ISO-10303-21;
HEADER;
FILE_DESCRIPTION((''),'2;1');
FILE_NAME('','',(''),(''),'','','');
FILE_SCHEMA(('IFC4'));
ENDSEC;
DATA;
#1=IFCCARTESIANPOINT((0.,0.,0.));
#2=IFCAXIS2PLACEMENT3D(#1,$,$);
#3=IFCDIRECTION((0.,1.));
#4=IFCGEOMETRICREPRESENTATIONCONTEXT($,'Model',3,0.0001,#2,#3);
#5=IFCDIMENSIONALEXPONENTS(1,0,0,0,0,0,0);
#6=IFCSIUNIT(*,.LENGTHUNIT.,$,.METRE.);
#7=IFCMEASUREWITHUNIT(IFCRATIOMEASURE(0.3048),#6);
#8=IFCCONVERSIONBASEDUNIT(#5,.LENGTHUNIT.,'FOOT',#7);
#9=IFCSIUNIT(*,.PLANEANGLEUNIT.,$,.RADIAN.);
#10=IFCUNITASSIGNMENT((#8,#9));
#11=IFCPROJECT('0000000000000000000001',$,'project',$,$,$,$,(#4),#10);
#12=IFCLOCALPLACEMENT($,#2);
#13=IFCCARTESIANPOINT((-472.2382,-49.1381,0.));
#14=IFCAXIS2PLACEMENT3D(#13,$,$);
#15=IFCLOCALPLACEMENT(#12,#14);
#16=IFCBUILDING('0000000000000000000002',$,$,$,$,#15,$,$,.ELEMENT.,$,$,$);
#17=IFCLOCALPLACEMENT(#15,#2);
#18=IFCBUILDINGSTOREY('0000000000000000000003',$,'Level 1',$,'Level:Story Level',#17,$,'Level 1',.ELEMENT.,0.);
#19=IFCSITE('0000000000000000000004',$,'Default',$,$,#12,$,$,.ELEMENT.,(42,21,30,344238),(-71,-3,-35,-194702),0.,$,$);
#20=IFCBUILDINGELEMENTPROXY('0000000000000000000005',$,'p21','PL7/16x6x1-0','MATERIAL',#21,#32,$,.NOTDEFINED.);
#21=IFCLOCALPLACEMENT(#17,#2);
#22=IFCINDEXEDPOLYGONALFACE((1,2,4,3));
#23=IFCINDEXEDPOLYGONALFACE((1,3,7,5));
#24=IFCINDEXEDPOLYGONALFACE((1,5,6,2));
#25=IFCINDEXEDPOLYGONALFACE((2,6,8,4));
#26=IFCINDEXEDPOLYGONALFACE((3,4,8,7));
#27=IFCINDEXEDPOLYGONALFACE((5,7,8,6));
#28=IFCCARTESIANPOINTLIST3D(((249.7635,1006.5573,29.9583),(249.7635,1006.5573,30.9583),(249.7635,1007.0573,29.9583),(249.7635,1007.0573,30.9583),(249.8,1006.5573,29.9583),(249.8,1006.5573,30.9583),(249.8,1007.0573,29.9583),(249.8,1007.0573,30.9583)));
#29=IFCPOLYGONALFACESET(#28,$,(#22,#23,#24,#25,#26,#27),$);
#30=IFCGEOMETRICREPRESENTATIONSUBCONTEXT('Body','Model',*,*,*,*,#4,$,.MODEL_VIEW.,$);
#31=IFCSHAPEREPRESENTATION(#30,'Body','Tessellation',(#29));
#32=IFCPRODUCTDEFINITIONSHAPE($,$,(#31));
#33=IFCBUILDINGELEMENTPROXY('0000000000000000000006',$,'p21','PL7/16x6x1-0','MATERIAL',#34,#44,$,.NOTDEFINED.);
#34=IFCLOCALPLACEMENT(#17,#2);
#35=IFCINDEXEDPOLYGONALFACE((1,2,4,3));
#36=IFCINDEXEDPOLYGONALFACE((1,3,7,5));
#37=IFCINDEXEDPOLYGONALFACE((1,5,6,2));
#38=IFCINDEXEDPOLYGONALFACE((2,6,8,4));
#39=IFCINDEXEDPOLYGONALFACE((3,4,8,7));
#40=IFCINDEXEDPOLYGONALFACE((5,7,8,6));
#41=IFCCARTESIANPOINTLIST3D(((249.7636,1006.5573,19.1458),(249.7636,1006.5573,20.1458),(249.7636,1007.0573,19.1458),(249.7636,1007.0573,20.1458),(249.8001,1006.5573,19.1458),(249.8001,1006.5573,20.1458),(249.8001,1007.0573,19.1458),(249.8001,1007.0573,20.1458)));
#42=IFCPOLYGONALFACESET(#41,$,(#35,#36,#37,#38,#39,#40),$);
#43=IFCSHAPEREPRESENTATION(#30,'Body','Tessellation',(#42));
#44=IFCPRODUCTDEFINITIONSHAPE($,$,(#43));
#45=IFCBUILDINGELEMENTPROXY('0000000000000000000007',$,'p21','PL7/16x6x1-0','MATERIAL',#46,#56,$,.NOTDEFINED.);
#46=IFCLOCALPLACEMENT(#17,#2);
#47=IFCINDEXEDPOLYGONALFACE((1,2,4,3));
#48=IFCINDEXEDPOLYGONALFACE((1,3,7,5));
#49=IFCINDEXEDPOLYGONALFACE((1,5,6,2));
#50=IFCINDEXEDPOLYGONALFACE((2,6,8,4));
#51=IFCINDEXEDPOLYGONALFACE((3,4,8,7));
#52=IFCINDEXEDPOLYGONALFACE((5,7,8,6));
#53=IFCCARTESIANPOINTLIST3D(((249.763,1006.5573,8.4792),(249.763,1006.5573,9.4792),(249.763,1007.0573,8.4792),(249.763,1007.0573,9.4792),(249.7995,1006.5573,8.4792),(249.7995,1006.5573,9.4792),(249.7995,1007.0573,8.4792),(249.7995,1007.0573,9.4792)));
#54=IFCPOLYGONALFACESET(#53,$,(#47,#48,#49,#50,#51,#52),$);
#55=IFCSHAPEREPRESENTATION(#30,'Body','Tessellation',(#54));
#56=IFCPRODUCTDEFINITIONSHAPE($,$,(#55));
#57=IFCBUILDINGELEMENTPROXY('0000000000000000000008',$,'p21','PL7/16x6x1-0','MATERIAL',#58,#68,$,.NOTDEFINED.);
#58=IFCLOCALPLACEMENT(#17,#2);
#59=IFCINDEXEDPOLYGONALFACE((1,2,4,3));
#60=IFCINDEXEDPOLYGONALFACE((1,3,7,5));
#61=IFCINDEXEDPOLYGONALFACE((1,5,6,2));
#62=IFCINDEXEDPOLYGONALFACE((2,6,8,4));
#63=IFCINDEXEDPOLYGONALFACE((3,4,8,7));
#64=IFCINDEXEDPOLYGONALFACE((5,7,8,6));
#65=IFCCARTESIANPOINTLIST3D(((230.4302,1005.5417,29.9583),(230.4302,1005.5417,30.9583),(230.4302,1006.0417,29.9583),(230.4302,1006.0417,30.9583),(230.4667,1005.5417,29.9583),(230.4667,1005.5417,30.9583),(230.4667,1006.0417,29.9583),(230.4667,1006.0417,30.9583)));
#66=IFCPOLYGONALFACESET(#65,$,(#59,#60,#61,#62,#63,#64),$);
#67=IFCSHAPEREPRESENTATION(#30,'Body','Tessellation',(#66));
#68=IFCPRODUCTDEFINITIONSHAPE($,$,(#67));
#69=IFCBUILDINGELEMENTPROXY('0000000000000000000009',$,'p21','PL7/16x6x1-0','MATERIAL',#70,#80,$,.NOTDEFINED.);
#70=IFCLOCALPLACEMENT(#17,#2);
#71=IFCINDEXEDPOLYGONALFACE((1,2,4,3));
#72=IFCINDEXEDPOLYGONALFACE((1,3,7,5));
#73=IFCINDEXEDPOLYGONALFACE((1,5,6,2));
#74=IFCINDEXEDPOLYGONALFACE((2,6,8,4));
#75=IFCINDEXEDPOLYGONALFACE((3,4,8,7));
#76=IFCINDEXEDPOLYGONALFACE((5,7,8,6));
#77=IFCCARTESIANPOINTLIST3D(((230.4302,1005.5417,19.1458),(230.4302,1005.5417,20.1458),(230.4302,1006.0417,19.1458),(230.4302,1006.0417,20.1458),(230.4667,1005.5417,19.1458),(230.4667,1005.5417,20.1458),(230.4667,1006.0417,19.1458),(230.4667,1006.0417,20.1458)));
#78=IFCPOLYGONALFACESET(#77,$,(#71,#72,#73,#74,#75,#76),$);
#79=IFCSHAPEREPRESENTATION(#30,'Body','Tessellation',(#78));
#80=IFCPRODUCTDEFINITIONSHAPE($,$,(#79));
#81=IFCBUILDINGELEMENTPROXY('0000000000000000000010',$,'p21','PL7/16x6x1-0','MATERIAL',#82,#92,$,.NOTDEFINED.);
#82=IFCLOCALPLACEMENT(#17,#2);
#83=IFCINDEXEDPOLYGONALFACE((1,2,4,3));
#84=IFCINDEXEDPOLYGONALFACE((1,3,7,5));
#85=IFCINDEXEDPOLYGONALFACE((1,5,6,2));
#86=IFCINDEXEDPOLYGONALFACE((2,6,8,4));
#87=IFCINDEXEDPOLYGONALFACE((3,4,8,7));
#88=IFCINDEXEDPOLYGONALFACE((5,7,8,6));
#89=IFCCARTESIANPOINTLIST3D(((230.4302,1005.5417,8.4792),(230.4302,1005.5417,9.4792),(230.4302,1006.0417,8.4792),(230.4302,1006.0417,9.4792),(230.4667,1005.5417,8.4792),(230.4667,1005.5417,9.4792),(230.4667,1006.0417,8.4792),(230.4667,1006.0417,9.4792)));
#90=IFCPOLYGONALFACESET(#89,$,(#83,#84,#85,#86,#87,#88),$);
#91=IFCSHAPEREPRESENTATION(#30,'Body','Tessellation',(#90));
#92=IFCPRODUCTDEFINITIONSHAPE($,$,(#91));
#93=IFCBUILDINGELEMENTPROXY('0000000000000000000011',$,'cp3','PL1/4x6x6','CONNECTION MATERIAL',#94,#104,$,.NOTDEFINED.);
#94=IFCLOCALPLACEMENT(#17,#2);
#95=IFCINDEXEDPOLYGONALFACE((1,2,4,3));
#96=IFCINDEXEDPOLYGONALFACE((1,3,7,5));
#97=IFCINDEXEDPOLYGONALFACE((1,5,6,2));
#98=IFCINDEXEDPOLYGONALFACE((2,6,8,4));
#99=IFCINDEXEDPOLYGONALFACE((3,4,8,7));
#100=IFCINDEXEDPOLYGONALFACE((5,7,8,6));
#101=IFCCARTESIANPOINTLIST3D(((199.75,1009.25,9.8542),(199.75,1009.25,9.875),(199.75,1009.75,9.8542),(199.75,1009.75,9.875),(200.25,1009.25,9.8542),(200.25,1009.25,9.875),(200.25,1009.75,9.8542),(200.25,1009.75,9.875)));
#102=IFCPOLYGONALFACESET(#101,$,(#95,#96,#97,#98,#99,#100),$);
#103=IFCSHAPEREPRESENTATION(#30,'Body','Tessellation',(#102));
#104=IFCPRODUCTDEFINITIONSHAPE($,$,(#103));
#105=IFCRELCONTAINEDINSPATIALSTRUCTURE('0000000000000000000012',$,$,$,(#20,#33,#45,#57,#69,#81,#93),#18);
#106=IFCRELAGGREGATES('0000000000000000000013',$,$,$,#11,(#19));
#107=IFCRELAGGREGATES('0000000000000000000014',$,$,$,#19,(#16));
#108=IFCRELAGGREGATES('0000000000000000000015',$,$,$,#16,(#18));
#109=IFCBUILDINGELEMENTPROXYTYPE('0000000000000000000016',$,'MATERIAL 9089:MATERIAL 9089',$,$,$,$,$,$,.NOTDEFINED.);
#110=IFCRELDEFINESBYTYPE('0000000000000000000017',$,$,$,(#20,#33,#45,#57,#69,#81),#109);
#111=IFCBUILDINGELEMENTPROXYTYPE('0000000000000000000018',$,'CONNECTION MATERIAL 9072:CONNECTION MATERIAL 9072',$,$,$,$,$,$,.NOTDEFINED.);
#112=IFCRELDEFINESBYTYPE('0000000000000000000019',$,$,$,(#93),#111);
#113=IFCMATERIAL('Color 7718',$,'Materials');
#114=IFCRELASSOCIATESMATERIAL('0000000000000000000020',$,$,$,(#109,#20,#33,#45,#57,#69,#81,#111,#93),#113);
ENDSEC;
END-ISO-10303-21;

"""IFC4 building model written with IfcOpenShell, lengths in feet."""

from ifc_helpers import new_model, entity, si_unit, converted_unit, direction, frame, origin, origin_2d_with_axis, place, context, subcontext, project, spatial, rectangle, extrude, source, transform, mapped, material, type_object, type_shapes, element, save


model = new_model("IFC4")

# Units and contexts
model_context = context("Model", 3, precision=0.0001, world=origin(), true_north=direction((0.0, 1.0)))
body_context = subcontext(model_context, "Body", "Model", "MODEL_VIEW")
ifc_project = project(units=[converted_unit("LENGTHUNIT", "FOOT", entity("IfcRatioMeasure", 0.3048), si_unit("LENGTHUNIT", "METRE"), dimensions=[1, 0, 0, 0, 0, 0, 0]), si_unit("PLANEANGLEUNIT", "RADIAN")], contexts=[model_context])

# Site, building, storey
site_placement = place(None, origin())
site = spatial("IfcSite", under=ifc_project, at=site_placement, Name="Default", CompositionType="ELEMENT", RefLatitude=(42, 21, 30, 344238), RefLongitude=(-71, -3, -35, -194702), RefElevation=0.0)
building_placement = place(site_placement, frame((-472.2382, -49.1381, 0.0)))
building = spatial("IfcBuilding", under=site, at=building_placement, CompositionType="ELEMENT")
storey_placement = place(building_placement, origin())
storey = spatial("IfcBuildingStorey", under=building, at=storey_placement, Name="Level 1", ObjectType="Level:Story Level", LongName="Level 1", CompositionType="ELEMENT", Elevation=0.0)

# Building element proxies
ifc_material_1 = material(Name="Color 7718", Category="Materials")
building_element_proxy_type_1 = type_object("IfcBuildingElementProxyType", Name="MATERIAL 9089:MATERIAL 9089", PredefinedType="NOTDEFINED", material=ifc_material_1)
shared_shape_1 = source(origin(), body_context, "Body", "SweptSolid", [
    extrude(rectangle(XDim=1.0, YDim=0.5, at=origin_2d_with_axis()), frame((0.5, -0.25, 0.0)), (0.0, 0.0, 1.0), 0.0365),
])
type_shapes(building_element_proxy_type_1, [shared_shape_1])
for number, where, z_axis, x_axis, name in (
    (1, (249.8, 1006.5573, 30.9583), (-1.0, 0.0, 0.0), (0.0, 0.0, -1.0), "p21"),
    (2, (249.8001, 1006.5573, 20.1458), (-1.0, 0.0, 0.0), (0.0, 0.0, -1.0), "p21"),
    (3, (249.7995, 1006.5573, 9.4792), (-1.0, 0.0, 0.0), (0.0, 0.0, -1.0), "p21"),
    (4, (230.4667, 1005.5417, 30.9583), (-1.0, 0.0, 0.0), (0.0, 0.0, -1.0), "p21"),
    (5, (230.4667, 1005.5417, 20.1458), (-1.0, 0.0, 0.0), (0.0, 0.0, -1.0), "p21"),
    (6, (230.4667, 1005.5417, 9.4792), (-1.0, 0.0, 0.0), (0.0, 0.0, -1.0), "p21"),
):
    element("IfcBuildingElementProxy", number, at=place(building_placement, frame(where, z_axis=z_axis, x_axis=x_axis)), inside=storey, type_object=building_element_proxy_type_1, material=ifc_material_1, Name=name, Description="PL7/16x6x1-0", ObjectType="MATERIAL", PredefinedType="NOTDEFINED", context=body_context, shape_type="MappedRepresentation", body=[
        mapped(shared_shape_1, transform((0.0, 0.0, 0.0), scale=1.0)),
    ])
building_element_proxy_type_2 = type_object("IfcBuildingElementProxyType", Name="CONNECTION MATERIAL 9072:CONNECTION MATERIAL 9072", PredefinedType="NOTDEFINED", material=ifc_material_1)
shared_shape_2 = source(origin(), body_context, "Body", "SweptSolid", [
    extrude(rectangle(XDim=0.5, YDim=0.5, at=origin_2d_with_axis()), frame((0.0, 0.0, -0.0208)), (0.0, 0.0, 1.0), 0.0208),
])
type_shapes(building_element_proxy_type_2, [shared_shape_2])
proxy_1_placement = place(building_placement, frame((200.0, 1009.5, 9.8542), z_axis=(0.0, 0.0, -1.0), x_axis=(1.0, 0.0, 0.0)))
element("IfcBuildingElementProxy", 7, at=proxy_1_placement, inside=storey, type_object=building_element_proxy_type_2, material=ifc_material_1, Name="cp3", Description="PL1/4x6x6", ObjectType="CONNECTION MATERIAL", PredefinedType="NOTDEFINED", context=body_context, shape_type="MappedRepresentation", body=[
    mapped(shared_shape_2, transform((0.0, 0.0, 0.0), scale=1.0)),
])

save(model, "model.ifc")
